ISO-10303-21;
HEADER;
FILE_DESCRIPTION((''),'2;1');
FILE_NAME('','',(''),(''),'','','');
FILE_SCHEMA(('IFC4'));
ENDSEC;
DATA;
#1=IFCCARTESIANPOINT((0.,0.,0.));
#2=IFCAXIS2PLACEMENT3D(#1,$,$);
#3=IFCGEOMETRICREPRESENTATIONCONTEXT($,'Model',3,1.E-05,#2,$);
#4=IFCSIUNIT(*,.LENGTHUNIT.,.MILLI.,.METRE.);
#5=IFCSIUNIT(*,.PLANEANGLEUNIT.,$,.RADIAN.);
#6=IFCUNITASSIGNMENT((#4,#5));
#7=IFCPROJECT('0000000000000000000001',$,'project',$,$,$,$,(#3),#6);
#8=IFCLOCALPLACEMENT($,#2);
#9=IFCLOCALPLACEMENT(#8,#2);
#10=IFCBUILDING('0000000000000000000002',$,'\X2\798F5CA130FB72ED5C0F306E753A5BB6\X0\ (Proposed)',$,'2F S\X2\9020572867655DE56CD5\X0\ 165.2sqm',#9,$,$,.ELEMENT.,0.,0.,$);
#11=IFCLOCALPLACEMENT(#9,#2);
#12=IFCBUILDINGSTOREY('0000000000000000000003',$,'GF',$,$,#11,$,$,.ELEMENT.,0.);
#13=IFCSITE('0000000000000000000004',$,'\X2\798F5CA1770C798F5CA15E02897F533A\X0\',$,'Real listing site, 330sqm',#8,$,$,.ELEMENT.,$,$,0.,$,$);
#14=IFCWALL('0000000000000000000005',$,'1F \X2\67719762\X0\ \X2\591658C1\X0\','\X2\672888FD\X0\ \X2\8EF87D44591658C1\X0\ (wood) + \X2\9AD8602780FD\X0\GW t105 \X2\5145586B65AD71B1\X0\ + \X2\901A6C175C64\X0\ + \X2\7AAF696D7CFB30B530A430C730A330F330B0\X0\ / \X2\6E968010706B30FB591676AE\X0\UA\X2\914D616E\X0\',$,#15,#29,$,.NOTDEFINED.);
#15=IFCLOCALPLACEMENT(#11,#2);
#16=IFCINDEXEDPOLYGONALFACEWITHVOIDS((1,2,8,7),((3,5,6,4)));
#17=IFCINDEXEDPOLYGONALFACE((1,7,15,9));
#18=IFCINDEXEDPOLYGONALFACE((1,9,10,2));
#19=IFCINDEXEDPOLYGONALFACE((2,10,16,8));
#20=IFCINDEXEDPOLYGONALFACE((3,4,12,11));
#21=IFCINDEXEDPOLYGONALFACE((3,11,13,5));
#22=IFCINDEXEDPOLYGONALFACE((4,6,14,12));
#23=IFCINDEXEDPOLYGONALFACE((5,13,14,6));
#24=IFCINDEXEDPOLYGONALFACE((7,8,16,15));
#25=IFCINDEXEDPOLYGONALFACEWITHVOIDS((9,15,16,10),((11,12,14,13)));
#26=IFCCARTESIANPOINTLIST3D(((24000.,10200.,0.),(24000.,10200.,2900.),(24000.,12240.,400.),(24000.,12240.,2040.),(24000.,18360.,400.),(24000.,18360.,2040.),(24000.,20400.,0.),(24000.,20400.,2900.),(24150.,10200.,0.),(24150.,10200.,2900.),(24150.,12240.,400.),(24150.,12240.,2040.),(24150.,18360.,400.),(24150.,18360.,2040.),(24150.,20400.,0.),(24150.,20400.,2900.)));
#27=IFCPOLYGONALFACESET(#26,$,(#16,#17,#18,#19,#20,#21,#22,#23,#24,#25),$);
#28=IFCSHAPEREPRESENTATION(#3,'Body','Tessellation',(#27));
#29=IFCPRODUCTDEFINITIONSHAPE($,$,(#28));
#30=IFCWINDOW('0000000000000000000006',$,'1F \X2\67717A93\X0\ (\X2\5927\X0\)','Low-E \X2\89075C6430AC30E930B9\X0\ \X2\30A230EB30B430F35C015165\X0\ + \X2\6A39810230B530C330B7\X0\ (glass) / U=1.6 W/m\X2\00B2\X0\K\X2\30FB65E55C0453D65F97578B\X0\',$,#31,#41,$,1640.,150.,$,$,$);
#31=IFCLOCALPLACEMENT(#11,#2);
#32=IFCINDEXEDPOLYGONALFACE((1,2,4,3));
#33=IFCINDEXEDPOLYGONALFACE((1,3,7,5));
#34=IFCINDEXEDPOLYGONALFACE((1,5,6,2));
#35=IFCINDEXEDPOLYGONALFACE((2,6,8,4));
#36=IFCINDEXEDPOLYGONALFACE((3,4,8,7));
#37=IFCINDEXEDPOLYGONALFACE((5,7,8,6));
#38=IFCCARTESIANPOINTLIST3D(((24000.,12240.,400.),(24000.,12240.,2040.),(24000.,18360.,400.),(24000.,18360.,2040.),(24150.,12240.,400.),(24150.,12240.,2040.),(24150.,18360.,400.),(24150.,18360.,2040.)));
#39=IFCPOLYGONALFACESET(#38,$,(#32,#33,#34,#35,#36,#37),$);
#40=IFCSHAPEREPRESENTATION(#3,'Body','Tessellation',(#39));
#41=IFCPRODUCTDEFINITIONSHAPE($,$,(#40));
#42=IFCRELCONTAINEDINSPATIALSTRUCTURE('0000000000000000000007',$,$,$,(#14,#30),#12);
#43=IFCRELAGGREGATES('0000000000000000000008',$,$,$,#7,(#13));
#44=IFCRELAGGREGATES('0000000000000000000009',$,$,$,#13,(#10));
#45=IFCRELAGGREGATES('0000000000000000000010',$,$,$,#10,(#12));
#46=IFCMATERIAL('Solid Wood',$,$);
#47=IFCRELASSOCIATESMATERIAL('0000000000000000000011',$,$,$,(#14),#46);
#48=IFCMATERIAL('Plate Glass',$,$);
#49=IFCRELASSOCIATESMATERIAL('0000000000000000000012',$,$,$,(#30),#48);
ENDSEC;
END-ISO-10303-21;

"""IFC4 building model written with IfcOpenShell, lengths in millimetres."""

from ifc_helpers import new_model, si_unit, frame, frame_2d, origin, place, context, project, spatial, rectangle, extrude, material, element, fill, save


model = new_model("IFC4")

# Units and contexts
model_context = context("Model", 3, precision=1e-05, world=origin())
ifc_project = project(units=[si_unit("LENGTHUNIT", "METRE", prefix="MILLI"), si_unit("PLANEANGLEUNIT", "RADIAN")], contexts=[model_context])

# Site, building, storey
site_placement = place(None, origin())
site = spatial("IfcSite", under=ifc_project, at=site_placement, Name="福岡県福岡市西区", ObjectType="Real listing site, 330sqm", CompositionType="ELEMENT", RefElevation=0.0)
building_placement = place(site_placement, origin())
building = spatial("IfcBuilding", under=site, at=building_placement, Name="福岡・狭小の町家 (Proposed)", ObjectType="2F S造在来工法 165.2sqm", CompositionType="ELEMENT", ElevationOfRefHeight=0.0, ElevationOfTerrain=0.0)
storey_placement = place(building_placement, origin())
storey = spatial("IfcBuildingStorey", under=building, at=storey_placement, Name="GF", CompositionType="ELEMENT", Elevation=0.0)

# Shared definitions
ifc_material_1 = material(Name="Solid Wood")

# Wall, opening, window
wall_1_placement = place(storey_placement, frame((12000.0, 5100.0, 0.0)))
wall_1 = element("IfcWall", 1, at=wall_1_placement, inside=storey, material=ifc_material_1, Name="1F 東面 外壁", Description="木製 軸組外壁 (wood) + 高性能GW t105 充填断熱 + 通気層 + 窯業系サイディング / 準耐火・外皮UA配慮", PredefinedType="NOTDEFINED", context=model_context, shape_type="SweptSolid", body=[
    extrude(rectangle(XDim=150.0, YDim=10200.0, at=frame_2d((75.0, 5100.0))), frame((12000.0, 5100.0, 0.0)), (0.0, 0.0, 1.0), 2900.0),
])
opening_1_placement = place(storey_placement, frame((12000.0, 6120.0, 200.0)))
opening_1 = element("IfcOpeningElement", 2, at=opening_1_placement, cuts=wall_1, PredefinedType="NOTDEFINED", context=model_context, shape_type="SweptSolid", body=[
    extrude(rectangle(XDim=150.0, YDim=6120.0, at=frame_2d((75.0, 3060.0))), frame((12000.0, 6120.0, 200.0)), (0.0, 0.0, 1.0), 1640.0),
])
ifc_material_2 = material(Name="Plate Glass")
window_1_placement = place(storey_placement, frame((12000.0, 6120.0, 200.0)))
window_1 = element("IfcWindow", 3, at=window_1_placement, inside=storey, material=ifc_material_2, Name="1F 東窓 (大)", Description="Low-E 複層ガラス アルゴン封入 + 樹脂サッシ (glass) / U=1.6 W/m²K・日射取得型", OverallHeight=1640.0, OverallWidth=150.0, context=model_context, shape_type="SweptSolid", body=[
    extrude(rectangle(XDim=150.0, YDim=6120.0, at=frame_2d((75.0, 3060.0))), frame((12000.0, 6120.0, 200.0)), (0.0, 0.0, 1.0), 1640.0),
])
fill(opening_1, window_1)

save(model, "model.ifc")
